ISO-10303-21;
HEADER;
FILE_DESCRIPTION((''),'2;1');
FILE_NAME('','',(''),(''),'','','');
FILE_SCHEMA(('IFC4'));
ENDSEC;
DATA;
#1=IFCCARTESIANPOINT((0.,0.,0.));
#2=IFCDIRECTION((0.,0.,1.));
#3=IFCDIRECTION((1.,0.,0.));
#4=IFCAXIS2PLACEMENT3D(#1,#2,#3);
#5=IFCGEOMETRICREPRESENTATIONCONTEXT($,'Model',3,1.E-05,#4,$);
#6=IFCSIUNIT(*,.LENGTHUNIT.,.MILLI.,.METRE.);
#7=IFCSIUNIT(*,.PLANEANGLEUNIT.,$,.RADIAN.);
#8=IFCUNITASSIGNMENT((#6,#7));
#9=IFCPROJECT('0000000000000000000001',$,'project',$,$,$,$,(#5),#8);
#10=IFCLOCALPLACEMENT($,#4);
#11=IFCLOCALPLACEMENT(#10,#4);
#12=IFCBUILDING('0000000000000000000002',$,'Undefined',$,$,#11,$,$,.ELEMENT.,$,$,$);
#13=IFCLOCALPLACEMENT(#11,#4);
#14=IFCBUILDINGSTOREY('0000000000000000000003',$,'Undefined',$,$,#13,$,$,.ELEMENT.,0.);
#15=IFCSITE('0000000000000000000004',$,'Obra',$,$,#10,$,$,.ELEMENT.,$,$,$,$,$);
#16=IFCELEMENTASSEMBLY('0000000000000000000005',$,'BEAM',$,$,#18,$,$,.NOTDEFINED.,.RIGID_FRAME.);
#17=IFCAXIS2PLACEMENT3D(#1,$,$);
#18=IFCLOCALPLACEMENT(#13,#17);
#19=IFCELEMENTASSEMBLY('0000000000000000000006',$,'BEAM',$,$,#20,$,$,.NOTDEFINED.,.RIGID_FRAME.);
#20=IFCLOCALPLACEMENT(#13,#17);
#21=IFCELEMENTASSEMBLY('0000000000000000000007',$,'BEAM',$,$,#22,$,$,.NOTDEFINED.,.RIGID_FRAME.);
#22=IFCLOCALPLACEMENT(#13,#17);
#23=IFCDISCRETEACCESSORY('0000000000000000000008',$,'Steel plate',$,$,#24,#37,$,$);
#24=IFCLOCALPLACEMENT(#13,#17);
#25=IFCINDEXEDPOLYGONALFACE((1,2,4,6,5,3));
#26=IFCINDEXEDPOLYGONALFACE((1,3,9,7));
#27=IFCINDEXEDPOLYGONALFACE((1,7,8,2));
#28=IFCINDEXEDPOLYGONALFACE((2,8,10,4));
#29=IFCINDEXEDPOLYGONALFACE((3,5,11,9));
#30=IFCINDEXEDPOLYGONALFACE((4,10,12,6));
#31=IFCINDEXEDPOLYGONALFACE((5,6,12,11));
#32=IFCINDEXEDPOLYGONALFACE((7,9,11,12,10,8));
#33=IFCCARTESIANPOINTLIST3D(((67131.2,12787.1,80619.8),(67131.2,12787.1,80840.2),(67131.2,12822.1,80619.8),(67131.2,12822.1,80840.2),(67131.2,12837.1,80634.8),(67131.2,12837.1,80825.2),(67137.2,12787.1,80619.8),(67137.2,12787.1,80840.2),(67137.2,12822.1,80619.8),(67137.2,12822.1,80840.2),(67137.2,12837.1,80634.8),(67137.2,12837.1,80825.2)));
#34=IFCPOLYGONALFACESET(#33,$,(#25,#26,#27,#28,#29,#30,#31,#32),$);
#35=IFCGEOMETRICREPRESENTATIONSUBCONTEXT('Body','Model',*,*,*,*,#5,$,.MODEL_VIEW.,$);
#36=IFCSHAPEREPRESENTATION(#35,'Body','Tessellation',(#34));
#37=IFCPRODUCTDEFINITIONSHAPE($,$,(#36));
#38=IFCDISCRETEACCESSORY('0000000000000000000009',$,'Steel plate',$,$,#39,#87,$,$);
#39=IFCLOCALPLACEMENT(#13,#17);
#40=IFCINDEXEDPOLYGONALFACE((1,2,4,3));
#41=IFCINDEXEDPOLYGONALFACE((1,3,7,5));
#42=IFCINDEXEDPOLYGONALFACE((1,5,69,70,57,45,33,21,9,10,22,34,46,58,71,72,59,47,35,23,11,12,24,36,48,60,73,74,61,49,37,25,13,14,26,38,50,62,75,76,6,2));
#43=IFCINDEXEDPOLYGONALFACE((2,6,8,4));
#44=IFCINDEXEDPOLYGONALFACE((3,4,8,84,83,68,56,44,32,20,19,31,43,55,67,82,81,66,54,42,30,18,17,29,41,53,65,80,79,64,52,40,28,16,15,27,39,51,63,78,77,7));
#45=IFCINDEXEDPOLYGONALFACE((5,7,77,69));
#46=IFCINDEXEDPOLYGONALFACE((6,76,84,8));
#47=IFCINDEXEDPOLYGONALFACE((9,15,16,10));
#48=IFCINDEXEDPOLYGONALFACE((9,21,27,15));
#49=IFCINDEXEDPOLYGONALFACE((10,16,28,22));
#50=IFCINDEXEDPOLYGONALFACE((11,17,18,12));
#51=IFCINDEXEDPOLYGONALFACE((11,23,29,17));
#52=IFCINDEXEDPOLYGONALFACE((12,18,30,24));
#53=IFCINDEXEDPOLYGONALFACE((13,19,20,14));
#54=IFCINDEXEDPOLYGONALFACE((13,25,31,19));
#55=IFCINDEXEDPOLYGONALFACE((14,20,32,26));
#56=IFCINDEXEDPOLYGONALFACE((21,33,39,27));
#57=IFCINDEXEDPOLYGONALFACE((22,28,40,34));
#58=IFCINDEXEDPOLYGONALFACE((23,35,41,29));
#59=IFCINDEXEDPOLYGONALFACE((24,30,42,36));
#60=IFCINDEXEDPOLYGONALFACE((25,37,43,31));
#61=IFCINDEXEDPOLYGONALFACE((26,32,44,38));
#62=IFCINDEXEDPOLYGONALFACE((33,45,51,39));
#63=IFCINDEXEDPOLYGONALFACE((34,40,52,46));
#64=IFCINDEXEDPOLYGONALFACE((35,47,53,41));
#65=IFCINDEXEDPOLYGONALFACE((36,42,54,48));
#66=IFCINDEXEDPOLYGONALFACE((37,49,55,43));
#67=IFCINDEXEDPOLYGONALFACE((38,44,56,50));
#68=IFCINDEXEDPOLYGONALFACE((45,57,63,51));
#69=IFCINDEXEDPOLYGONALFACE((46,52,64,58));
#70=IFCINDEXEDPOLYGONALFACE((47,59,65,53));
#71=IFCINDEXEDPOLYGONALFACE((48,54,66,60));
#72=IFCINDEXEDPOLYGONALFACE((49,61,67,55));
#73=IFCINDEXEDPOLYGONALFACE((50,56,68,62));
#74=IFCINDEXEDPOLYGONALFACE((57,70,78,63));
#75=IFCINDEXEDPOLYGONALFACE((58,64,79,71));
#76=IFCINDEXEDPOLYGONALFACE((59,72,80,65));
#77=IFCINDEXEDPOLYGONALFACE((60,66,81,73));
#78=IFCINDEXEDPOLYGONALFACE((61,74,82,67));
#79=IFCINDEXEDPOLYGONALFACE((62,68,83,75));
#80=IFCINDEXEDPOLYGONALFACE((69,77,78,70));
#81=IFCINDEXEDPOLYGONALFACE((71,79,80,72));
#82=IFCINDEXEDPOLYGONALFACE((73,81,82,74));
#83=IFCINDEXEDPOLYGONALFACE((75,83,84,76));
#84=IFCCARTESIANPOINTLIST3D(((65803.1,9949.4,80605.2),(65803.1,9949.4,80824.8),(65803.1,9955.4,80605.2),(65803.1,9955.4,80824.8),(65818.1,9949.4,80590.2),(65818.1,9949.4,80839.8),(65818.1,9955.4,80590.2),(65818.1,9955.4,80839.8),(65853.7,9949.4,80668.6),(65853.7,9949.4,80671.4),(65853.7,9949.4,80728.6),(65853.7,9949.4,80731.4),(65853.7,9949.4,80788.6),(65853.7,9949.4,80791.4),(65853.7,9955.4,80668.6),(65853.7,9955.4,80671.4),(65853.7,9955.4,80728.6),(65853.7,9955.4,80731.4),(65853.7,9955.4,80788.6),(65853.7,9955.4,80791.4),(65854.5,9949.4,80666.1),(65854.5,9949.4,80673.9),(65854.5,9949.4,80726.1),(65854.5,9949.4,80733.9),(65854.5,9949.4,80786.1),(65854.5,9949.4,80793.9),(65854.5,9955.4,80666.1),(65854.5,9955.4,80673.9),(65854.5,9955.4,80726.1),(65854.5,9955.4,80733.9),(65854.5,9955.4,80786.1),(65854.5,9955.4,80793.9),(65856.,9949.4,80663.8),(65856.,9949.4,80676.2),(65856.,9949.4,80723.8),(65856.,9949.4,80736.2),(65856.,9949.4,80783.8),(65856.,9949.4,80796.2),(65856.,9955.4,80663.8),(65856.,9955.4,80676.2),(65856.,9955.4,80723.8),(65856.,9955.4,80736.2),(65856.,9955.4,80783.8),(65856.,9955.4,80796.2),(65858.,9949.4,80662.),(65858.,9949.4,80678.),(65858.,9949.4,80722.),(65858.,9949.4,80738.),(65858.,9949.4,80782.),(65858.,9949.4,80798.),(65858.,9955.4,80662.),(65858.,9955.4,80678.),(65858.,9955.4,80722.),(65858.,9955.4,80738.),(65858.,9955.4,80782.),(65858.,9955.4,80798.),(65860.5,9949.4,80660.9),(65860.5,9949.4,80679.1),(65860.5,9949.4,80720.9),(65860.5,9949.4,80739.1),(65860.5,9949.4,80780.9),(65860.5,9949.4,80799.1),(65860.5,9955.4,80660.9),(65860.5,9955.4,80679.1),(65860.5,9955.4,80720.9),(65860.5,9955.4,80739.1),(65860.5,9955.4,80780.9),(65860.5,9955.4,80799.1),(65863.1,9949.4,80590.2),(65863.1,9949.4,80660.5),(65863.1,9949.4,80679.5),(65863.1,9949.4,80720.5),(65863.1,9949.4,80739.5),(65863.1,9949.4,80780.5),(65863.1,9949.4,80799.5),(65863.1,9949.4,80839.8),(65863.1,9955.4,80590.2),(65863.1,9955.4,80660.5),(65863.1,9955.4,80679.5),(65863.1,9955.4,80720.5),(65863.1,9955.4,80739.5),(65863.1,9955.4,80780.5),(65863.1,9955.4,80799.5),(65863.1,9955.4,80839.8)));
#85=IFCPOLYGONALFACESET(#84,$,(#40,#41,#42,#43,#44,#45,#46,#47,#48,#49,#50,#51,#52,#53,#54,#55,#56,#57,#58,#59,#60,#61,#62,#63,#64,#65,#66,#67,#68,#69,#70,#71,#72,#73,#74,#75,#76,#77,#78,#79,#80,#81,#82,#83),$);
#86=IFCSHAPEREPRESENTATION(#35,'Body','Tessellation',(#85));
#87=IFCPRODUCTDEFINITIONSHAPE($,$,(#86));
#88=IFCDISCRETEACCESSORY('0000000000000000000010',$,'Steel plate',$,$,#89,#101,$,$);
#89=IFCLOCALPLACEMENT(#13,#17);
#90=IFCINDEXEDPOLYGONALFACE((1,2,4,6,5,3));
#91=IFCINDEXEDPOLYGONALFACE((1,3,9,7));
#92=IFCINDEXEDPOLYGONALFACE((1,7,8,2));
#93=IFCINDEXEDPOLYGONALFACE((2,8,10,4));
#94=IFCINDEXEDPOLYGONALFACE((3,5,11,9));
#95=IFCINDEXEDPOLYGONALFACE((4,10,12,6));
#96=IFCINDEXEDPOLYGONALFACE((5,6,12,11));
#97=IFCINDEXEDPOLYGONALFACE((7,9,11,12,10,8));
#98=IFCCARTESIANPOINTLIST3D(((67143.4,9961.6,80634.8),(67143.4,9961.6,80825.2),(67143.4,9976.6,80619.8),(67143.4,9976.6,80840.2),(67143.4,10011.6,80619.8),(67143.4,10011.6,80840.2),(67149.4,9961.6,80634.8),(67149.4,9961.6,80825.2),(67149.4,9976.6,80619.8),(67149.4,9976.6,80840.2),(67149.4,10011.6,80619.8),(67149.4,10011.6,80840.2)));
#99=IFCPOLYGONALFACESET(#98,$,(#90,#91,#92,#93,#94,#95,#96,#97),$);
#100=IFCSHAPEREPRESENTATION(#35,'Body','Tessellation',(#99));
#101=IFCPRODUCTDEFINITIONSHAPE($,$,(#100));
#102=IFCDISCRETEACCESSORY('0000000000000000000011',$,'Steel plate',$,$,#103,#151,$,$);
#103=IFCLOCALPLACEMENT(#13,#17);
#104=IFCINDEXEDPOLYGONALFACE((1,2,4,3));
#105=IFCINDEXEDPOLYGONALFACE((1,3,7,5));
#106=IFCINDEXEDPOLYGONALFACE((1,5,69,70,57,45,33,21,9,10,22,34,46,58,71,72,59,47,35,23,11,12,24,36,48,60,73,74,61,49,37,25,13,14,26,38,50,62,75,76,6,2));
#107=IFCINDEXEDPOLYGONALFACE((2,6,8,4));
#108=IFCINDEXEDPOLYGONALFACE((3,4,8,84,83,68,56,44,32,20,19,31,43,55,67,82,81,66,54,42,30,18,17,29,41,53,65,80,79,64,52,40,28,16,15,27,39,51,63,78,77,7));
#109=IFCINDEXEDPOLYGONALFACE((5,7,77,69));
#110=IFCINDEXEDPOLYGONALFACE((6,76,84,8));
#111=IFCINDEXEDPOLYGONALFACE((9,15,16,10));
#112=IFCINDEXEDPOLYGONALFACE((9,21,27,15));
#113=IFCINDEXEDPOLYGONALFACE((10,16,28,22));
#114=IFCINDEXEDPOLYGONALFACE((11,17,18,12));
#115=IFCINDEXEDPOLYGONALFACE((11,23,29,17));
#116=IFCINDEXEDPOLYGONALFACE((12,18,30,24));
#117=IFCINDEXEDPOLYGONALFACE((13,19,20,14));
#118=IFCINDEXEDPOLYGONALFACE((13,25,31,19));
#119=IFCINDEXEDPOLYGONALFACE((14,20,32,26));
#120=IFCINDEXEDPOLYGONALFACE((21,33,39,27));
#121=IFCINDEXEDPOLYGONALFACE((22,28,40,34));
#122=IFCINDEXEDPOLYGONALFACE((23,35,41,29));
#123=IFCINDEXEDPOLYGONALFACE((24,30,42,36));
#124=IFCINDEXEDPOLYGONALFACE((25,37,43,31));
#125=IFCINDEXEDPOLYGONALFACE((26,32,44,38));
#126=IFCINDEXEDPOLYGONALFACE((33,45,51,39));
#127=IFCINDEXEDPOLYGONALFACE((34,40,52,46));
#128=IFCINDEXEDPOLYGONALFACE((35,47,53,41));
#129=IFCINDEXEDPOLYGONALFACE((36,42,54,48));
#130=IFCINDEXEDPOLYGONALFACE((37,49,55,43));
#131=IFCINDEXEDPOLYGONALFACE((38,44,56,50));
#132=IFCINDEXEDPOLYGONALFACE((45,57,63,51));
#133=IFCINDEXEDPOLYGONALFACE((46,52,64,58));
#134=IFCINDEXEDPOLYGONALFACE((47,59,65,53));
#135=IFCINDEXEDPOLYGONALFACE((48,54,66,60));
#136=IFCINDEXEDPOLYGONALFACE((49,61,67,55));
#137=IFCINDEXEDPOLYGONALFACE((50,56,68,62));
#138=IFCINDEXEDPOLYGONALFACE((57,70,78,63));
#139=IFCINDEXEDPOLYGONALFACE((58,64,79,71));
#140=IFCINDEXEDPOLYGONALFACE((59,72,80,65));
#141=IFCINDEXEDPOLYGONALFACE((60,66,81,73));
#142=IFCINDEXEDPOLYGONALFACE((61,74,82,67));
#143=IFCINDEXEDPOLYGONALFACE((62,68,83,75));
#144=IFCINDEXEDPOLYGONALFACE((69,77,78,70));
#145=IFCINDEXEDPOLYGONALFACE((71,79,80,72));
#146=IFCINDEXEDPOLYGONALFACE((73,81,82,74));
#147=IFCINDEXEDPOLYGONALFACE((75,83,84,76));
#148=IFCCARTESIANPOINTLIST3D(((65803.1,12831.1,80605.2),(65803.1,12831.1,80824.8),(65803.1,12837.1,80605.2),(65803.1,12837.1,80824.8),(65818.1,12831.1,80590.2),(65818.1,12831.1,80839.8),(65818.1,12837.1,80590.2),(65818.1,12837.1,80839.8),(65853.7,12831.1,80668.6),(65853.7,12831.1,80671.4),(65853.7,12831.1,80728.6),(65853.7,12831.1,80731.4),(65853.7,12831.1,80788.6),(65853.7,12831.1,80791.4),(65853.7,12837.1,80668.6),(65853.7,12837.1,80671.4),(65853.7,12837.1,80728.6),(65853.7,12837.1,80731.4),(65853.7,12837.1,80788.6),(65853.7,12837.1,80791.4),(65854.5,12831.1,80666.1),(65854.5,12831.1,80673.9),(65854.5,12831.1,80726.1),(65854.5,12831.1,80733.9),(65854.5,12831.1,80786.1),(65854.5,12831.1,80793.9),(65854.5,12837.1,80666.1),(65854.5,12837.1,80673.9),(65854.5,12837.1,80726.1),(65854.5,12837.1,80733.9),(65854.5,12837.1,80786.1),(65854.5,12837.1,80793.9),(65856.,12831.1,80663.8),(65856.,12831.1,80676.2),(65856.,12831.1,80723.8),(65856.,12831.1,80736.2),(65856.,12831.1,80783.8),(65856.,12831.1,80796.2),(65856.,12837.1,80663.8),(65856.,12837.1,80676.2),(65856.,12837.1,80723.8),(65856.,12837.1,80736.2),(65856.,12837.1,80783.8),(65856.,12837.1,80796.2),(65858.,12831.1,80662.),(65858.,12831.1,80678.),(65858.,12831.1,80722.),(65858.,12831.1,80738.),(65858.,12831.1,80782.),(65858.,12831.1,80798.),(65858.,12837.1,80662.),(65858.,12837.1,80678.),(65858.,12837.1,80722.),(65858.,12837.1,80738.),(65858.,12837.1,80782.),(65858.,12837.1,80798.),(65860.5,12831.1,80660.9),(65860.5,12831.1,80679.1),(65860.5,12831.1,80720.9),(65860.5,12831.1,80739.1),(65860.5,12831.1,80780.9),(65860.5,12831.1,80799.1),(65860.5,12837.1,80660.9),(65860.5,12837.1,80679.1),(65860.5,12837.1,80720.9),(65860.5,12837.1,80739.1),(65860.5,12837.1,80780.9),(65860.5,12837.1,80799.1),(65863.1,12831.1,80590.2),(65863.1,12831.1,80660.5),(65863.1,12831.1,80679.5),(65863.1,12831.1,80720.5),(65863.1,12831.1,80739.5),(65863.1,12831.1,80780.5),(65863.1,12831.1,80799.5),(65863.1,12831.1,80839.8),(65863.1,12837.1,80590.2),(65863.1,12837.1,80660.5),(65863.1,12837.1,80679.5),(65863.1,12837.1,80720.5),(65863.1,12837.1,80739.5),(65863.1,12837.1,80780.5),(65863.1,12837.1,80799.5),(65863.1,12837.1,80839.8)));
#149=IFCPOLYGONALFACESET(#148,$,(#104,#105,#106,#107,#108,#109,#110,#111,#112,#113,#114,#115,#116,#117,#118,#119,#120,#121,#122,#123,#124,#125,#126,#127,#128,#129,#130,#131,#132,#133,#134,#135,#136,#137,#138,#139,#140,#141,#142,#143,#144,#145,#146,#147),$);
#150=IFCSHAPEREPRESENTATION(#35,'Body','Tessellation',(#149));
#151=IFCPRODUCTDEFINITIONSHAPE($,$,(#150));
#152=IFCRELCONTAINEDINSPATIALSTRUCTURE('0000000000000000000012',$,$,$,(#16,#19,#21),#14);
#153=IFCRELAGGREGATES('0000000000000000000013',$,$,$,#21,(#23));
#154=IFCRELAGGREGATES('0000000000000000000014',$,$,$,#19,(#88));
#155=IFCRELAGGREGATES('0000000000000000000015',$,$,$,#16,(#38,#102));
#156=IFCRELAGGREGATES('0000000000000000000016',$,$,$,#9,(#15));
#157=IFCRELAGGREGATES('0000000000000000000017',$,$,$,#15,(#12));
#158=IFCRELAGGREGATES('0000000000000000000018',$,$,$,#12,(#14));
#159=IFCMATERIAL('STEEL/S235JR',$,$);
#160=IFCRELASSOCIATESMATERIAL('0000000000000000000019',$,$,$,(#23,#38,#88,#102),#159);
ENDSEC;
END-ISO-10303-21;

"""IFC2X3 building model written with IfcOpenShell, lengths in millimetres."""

from ifc_helpers import new_model, si_unit, frame, origin_with_axes, origin_2d_with_axis, place, context, subcontext, project, spatial, polyline, circle, outline, extrude, source, transform, mapped, material, element, aggregate, save


model = new_model("IFC2X3")

# Units and contexts
model_context = context("Model", 3, precision=1e-05, world=origin_with_axes())
body_context = subcontext(model_context, "Body", "Model", "MODEL_VIEW")
ifc_project = project(units=[si_unit("LENGTHUNIT", "METRE", prefix="MILLI"), si_unit("PLANEANGLEUNIT", "RADIAN")], contexts=[model_context])

# Site, building, storey
site_placement = place(None, origin_with_axes())
site = spatial("IfcSite", under=ifc_project, at=site_placement, Name="Obra", CompositionType="ELEMENT")
building_placement = place(site_placement, origin_with_axes())
building = spatial("IfcBuilding", under=site, at=building_placement, Name="Undefined", CompositionType="ELEMENT")
storey_placement = place(building_placement, origin_with_axes())
storey = spatial("IfcBuildingStorey", under=building, at=storey_placement, Name="Undefined", CompositionType="ELEMENT", Elevation=0.0)

# Element assemblies
ifc_material = material(Name="STEEL/S235JR")
assembly_1_placement = place(storey_placement, origin_with_axes())
assembly_1 = element("IfcElementAssembly", 1, at=assembly_1_placement, inside=storey, Name="BEAM", AssemblyPlace="NOTDEFINED", PredefinedType="RIGID_FRAME")
assembly_2_placement = place(storey_placement, origin_with_axes())
assembly_2 = element("IfcElementAssembly", 2, at=assembly_2_placement, inside=storey, Name="BEAM", AssemblyPlace="NOTDEFINED", PredefinedType="RIGID_FRAME")

# Element assembly, discrete accessory
assembly_3_placement = place(storey_placement, origin_with_axes())
assembly_3 = element("IfcElementAssembly", 3, at=assembly_3_placement, inside=storey, Name="BEAM", AssemblyPlace="NOTDEFINED", PredefinedType="RIGID_FRAME")
discrete_accessory_1_placement = place(assembly_3_placement, frame((67134.2, 12787.1, 80619.8), z_axis=(1.0, 0.0, 0.0), x_axis=(0.0, 1.0, 0.0)))
discrete_accessory_1 = element("IfcDiscreteAccessory", 4, at=discrete_accessory_1_placement, material=ifc_material, Name="Steel plate", context=body_context, shape_type="SweptSolid", body=[
    extrude(outline(polyline([(0.0, 0.0), (35.0, 0.0), (50.0, 15.0), (50.0, 205.4), (35.0, 220.4), (0.0, 220.4), (0.0, 0.0)])), frame((0.0, 0.0, -3.0), z_axis=(0.0, 0.0, 1.0), x_axis=(1.0, 0.0, 0.0)), (0.0, 0.0, 1.0), 6.0),
])
aggregate(assembly_3, [discrete_accessory_1])

# Discrete accessory, opening
discrete_accessory_2_placement = place(assembly_1_placement, frame((65863.1, 9952.4, 80590.2), z_axis=(0.0, 1.0, 0.0), x_axis=(-1.0, 0.0, 0.0)))
discrete_accessory_2 = element("IfcDiscreteAccessory", 5, at=discrete_accessory_2_placement, material=ifc_material, Name="Steel plate", context=body_context, shape_type="SweptSolid", body=[
    extrude(outline(polyline([(0.0, 0.0), (45.0, 0.0), (60.0, 15.0), (60.0, 234.6), (45.0, 249.6), (0.0, 249.6), (0.0, 0.0)])), frame((0.0, 0.0, -3.0), z_axis=(0.0, 0.0, 1.0), x_axis=(1.0, 0.0, 0.0)), (0.0, 0.0, 1.0), 6.0),
])
shared_shape_1 = source(origin_with_axes(), body_context, "Body", "SweptSolid", [
    extrude(circle(Radius=9.5, at=origin_2d_with_axis()), frame((0.0, -9.2, 0.0), z_axis=(0.0, 1.0, 0.0), x_axis=(1.0, 0.0, 0.0)), (0.0, 0.0, 1.0), 6.2),
])
opening_1_placement = place(assembly_1_placement, frame((65813.1, 9958.5, 80850.0), z_axis=(1.0, 0.0, 0.0), x_axis=(0.0, 0.0, -1.0)))
element("IfcOpeningElement", 6, at=opening_1_placement, cuts=discrete_accessory_2, ObjectType="Opening", context=body_context, shape_type="MappedRepresentation", body=[
    mapped(shared_shape_1, transform((60.0, 0.0, 50.0))),
    mapped(shared_shape_1, transform((120.0, 0.0, 50.0))),
    mapped(shared_shape_1, transform((180.0, 0.0, 50.0))),
])

# Discrete accessory
discrete_accessory_3_placement = place(assembly_2_placement, frame((67146.4, 10011.6, 80619.8), z_axis=(-1.0, 0.0, 0.0), x_axis=(0.0, -1.0, 0.0)))
discrete_accessory_3 = element("IfcDiscreteAccessory", 7, at=discrete_accessory_3_placement, material=ifc_material, Name="Steel plate", context=body_context, shape_type="SweptSolid", body=[
    extrude(outline(polyline([(0.0, 0.0), (35.0, 0.0), (50.0, 15.0), (50.0, 205.4), (35.0, 220.4), (0.0, 220.4), (0.0, 0.0)])), frame((0.0, 0.0, -3.0), z_axis=(0.0, 0.0, 1.0), x_axis=(1.0, 0.0, 0.0)), (0.0, 0.0, 1.0), 6.0),
])
aggregate(assembly_2, [discrete_accessory_3])

# Discrete accessory, opening
discrete_accessory_4_placement = place(assembly_1_placement, frame((65863.1, 12834.1, 80590.2), z_axis=(0.0, 1.0, 0.0), x_axis=(-1.0, 0.0, 0.0)))
discrete_accessory_4 = element("IfcDiscreteAccessory", 8, at=discrete_accessory_4_placement, material=ifc_material, Name="Steel plate", context=body_context, shape_type="SweptSolid", body=[
    extrude(outline(polyline([(0.0, 0.0), (45.0, 0.0), (60.0, 15.0), (60.0, 234.6), (45.0, 249.6), (0.0, 249.6), (0.0, 0.0)])), frame((0.0, 0.0, -3.0), z_axis=(0.0, 0.0, 1.0), x_axis=(1.0, 0.0, 0.0)), (0.0, 0.0, 1.0), 6.0),
])
opening_2_placement = place(assembly_1_placement, frame((65813.1, 12840.2, 80850.0), z_axis=(1.0, 0.0, 0.0), x_axis=(0.0, 0.0, -1.0)))
element("IfcOpeningElement", 9, at=opening_2_placement, cuts=discrete_accessory_4, ObjectType="Opening", context=body_context, shape_type="MappedRepresentation", body=[
    mapped(shared_shape_1, transform((60.0, 0.0, 50.0))),
    mapped(shared_shape_1, transform((120.0, 0.0, 50.0))),
    mapped(shared_shape_1, transform((180.0, 0.0, 50.0))),
])
aggregate(assembly_1, [discrete_accessory_2, discrete_accessory_4])

save(model, "model.ifc")
